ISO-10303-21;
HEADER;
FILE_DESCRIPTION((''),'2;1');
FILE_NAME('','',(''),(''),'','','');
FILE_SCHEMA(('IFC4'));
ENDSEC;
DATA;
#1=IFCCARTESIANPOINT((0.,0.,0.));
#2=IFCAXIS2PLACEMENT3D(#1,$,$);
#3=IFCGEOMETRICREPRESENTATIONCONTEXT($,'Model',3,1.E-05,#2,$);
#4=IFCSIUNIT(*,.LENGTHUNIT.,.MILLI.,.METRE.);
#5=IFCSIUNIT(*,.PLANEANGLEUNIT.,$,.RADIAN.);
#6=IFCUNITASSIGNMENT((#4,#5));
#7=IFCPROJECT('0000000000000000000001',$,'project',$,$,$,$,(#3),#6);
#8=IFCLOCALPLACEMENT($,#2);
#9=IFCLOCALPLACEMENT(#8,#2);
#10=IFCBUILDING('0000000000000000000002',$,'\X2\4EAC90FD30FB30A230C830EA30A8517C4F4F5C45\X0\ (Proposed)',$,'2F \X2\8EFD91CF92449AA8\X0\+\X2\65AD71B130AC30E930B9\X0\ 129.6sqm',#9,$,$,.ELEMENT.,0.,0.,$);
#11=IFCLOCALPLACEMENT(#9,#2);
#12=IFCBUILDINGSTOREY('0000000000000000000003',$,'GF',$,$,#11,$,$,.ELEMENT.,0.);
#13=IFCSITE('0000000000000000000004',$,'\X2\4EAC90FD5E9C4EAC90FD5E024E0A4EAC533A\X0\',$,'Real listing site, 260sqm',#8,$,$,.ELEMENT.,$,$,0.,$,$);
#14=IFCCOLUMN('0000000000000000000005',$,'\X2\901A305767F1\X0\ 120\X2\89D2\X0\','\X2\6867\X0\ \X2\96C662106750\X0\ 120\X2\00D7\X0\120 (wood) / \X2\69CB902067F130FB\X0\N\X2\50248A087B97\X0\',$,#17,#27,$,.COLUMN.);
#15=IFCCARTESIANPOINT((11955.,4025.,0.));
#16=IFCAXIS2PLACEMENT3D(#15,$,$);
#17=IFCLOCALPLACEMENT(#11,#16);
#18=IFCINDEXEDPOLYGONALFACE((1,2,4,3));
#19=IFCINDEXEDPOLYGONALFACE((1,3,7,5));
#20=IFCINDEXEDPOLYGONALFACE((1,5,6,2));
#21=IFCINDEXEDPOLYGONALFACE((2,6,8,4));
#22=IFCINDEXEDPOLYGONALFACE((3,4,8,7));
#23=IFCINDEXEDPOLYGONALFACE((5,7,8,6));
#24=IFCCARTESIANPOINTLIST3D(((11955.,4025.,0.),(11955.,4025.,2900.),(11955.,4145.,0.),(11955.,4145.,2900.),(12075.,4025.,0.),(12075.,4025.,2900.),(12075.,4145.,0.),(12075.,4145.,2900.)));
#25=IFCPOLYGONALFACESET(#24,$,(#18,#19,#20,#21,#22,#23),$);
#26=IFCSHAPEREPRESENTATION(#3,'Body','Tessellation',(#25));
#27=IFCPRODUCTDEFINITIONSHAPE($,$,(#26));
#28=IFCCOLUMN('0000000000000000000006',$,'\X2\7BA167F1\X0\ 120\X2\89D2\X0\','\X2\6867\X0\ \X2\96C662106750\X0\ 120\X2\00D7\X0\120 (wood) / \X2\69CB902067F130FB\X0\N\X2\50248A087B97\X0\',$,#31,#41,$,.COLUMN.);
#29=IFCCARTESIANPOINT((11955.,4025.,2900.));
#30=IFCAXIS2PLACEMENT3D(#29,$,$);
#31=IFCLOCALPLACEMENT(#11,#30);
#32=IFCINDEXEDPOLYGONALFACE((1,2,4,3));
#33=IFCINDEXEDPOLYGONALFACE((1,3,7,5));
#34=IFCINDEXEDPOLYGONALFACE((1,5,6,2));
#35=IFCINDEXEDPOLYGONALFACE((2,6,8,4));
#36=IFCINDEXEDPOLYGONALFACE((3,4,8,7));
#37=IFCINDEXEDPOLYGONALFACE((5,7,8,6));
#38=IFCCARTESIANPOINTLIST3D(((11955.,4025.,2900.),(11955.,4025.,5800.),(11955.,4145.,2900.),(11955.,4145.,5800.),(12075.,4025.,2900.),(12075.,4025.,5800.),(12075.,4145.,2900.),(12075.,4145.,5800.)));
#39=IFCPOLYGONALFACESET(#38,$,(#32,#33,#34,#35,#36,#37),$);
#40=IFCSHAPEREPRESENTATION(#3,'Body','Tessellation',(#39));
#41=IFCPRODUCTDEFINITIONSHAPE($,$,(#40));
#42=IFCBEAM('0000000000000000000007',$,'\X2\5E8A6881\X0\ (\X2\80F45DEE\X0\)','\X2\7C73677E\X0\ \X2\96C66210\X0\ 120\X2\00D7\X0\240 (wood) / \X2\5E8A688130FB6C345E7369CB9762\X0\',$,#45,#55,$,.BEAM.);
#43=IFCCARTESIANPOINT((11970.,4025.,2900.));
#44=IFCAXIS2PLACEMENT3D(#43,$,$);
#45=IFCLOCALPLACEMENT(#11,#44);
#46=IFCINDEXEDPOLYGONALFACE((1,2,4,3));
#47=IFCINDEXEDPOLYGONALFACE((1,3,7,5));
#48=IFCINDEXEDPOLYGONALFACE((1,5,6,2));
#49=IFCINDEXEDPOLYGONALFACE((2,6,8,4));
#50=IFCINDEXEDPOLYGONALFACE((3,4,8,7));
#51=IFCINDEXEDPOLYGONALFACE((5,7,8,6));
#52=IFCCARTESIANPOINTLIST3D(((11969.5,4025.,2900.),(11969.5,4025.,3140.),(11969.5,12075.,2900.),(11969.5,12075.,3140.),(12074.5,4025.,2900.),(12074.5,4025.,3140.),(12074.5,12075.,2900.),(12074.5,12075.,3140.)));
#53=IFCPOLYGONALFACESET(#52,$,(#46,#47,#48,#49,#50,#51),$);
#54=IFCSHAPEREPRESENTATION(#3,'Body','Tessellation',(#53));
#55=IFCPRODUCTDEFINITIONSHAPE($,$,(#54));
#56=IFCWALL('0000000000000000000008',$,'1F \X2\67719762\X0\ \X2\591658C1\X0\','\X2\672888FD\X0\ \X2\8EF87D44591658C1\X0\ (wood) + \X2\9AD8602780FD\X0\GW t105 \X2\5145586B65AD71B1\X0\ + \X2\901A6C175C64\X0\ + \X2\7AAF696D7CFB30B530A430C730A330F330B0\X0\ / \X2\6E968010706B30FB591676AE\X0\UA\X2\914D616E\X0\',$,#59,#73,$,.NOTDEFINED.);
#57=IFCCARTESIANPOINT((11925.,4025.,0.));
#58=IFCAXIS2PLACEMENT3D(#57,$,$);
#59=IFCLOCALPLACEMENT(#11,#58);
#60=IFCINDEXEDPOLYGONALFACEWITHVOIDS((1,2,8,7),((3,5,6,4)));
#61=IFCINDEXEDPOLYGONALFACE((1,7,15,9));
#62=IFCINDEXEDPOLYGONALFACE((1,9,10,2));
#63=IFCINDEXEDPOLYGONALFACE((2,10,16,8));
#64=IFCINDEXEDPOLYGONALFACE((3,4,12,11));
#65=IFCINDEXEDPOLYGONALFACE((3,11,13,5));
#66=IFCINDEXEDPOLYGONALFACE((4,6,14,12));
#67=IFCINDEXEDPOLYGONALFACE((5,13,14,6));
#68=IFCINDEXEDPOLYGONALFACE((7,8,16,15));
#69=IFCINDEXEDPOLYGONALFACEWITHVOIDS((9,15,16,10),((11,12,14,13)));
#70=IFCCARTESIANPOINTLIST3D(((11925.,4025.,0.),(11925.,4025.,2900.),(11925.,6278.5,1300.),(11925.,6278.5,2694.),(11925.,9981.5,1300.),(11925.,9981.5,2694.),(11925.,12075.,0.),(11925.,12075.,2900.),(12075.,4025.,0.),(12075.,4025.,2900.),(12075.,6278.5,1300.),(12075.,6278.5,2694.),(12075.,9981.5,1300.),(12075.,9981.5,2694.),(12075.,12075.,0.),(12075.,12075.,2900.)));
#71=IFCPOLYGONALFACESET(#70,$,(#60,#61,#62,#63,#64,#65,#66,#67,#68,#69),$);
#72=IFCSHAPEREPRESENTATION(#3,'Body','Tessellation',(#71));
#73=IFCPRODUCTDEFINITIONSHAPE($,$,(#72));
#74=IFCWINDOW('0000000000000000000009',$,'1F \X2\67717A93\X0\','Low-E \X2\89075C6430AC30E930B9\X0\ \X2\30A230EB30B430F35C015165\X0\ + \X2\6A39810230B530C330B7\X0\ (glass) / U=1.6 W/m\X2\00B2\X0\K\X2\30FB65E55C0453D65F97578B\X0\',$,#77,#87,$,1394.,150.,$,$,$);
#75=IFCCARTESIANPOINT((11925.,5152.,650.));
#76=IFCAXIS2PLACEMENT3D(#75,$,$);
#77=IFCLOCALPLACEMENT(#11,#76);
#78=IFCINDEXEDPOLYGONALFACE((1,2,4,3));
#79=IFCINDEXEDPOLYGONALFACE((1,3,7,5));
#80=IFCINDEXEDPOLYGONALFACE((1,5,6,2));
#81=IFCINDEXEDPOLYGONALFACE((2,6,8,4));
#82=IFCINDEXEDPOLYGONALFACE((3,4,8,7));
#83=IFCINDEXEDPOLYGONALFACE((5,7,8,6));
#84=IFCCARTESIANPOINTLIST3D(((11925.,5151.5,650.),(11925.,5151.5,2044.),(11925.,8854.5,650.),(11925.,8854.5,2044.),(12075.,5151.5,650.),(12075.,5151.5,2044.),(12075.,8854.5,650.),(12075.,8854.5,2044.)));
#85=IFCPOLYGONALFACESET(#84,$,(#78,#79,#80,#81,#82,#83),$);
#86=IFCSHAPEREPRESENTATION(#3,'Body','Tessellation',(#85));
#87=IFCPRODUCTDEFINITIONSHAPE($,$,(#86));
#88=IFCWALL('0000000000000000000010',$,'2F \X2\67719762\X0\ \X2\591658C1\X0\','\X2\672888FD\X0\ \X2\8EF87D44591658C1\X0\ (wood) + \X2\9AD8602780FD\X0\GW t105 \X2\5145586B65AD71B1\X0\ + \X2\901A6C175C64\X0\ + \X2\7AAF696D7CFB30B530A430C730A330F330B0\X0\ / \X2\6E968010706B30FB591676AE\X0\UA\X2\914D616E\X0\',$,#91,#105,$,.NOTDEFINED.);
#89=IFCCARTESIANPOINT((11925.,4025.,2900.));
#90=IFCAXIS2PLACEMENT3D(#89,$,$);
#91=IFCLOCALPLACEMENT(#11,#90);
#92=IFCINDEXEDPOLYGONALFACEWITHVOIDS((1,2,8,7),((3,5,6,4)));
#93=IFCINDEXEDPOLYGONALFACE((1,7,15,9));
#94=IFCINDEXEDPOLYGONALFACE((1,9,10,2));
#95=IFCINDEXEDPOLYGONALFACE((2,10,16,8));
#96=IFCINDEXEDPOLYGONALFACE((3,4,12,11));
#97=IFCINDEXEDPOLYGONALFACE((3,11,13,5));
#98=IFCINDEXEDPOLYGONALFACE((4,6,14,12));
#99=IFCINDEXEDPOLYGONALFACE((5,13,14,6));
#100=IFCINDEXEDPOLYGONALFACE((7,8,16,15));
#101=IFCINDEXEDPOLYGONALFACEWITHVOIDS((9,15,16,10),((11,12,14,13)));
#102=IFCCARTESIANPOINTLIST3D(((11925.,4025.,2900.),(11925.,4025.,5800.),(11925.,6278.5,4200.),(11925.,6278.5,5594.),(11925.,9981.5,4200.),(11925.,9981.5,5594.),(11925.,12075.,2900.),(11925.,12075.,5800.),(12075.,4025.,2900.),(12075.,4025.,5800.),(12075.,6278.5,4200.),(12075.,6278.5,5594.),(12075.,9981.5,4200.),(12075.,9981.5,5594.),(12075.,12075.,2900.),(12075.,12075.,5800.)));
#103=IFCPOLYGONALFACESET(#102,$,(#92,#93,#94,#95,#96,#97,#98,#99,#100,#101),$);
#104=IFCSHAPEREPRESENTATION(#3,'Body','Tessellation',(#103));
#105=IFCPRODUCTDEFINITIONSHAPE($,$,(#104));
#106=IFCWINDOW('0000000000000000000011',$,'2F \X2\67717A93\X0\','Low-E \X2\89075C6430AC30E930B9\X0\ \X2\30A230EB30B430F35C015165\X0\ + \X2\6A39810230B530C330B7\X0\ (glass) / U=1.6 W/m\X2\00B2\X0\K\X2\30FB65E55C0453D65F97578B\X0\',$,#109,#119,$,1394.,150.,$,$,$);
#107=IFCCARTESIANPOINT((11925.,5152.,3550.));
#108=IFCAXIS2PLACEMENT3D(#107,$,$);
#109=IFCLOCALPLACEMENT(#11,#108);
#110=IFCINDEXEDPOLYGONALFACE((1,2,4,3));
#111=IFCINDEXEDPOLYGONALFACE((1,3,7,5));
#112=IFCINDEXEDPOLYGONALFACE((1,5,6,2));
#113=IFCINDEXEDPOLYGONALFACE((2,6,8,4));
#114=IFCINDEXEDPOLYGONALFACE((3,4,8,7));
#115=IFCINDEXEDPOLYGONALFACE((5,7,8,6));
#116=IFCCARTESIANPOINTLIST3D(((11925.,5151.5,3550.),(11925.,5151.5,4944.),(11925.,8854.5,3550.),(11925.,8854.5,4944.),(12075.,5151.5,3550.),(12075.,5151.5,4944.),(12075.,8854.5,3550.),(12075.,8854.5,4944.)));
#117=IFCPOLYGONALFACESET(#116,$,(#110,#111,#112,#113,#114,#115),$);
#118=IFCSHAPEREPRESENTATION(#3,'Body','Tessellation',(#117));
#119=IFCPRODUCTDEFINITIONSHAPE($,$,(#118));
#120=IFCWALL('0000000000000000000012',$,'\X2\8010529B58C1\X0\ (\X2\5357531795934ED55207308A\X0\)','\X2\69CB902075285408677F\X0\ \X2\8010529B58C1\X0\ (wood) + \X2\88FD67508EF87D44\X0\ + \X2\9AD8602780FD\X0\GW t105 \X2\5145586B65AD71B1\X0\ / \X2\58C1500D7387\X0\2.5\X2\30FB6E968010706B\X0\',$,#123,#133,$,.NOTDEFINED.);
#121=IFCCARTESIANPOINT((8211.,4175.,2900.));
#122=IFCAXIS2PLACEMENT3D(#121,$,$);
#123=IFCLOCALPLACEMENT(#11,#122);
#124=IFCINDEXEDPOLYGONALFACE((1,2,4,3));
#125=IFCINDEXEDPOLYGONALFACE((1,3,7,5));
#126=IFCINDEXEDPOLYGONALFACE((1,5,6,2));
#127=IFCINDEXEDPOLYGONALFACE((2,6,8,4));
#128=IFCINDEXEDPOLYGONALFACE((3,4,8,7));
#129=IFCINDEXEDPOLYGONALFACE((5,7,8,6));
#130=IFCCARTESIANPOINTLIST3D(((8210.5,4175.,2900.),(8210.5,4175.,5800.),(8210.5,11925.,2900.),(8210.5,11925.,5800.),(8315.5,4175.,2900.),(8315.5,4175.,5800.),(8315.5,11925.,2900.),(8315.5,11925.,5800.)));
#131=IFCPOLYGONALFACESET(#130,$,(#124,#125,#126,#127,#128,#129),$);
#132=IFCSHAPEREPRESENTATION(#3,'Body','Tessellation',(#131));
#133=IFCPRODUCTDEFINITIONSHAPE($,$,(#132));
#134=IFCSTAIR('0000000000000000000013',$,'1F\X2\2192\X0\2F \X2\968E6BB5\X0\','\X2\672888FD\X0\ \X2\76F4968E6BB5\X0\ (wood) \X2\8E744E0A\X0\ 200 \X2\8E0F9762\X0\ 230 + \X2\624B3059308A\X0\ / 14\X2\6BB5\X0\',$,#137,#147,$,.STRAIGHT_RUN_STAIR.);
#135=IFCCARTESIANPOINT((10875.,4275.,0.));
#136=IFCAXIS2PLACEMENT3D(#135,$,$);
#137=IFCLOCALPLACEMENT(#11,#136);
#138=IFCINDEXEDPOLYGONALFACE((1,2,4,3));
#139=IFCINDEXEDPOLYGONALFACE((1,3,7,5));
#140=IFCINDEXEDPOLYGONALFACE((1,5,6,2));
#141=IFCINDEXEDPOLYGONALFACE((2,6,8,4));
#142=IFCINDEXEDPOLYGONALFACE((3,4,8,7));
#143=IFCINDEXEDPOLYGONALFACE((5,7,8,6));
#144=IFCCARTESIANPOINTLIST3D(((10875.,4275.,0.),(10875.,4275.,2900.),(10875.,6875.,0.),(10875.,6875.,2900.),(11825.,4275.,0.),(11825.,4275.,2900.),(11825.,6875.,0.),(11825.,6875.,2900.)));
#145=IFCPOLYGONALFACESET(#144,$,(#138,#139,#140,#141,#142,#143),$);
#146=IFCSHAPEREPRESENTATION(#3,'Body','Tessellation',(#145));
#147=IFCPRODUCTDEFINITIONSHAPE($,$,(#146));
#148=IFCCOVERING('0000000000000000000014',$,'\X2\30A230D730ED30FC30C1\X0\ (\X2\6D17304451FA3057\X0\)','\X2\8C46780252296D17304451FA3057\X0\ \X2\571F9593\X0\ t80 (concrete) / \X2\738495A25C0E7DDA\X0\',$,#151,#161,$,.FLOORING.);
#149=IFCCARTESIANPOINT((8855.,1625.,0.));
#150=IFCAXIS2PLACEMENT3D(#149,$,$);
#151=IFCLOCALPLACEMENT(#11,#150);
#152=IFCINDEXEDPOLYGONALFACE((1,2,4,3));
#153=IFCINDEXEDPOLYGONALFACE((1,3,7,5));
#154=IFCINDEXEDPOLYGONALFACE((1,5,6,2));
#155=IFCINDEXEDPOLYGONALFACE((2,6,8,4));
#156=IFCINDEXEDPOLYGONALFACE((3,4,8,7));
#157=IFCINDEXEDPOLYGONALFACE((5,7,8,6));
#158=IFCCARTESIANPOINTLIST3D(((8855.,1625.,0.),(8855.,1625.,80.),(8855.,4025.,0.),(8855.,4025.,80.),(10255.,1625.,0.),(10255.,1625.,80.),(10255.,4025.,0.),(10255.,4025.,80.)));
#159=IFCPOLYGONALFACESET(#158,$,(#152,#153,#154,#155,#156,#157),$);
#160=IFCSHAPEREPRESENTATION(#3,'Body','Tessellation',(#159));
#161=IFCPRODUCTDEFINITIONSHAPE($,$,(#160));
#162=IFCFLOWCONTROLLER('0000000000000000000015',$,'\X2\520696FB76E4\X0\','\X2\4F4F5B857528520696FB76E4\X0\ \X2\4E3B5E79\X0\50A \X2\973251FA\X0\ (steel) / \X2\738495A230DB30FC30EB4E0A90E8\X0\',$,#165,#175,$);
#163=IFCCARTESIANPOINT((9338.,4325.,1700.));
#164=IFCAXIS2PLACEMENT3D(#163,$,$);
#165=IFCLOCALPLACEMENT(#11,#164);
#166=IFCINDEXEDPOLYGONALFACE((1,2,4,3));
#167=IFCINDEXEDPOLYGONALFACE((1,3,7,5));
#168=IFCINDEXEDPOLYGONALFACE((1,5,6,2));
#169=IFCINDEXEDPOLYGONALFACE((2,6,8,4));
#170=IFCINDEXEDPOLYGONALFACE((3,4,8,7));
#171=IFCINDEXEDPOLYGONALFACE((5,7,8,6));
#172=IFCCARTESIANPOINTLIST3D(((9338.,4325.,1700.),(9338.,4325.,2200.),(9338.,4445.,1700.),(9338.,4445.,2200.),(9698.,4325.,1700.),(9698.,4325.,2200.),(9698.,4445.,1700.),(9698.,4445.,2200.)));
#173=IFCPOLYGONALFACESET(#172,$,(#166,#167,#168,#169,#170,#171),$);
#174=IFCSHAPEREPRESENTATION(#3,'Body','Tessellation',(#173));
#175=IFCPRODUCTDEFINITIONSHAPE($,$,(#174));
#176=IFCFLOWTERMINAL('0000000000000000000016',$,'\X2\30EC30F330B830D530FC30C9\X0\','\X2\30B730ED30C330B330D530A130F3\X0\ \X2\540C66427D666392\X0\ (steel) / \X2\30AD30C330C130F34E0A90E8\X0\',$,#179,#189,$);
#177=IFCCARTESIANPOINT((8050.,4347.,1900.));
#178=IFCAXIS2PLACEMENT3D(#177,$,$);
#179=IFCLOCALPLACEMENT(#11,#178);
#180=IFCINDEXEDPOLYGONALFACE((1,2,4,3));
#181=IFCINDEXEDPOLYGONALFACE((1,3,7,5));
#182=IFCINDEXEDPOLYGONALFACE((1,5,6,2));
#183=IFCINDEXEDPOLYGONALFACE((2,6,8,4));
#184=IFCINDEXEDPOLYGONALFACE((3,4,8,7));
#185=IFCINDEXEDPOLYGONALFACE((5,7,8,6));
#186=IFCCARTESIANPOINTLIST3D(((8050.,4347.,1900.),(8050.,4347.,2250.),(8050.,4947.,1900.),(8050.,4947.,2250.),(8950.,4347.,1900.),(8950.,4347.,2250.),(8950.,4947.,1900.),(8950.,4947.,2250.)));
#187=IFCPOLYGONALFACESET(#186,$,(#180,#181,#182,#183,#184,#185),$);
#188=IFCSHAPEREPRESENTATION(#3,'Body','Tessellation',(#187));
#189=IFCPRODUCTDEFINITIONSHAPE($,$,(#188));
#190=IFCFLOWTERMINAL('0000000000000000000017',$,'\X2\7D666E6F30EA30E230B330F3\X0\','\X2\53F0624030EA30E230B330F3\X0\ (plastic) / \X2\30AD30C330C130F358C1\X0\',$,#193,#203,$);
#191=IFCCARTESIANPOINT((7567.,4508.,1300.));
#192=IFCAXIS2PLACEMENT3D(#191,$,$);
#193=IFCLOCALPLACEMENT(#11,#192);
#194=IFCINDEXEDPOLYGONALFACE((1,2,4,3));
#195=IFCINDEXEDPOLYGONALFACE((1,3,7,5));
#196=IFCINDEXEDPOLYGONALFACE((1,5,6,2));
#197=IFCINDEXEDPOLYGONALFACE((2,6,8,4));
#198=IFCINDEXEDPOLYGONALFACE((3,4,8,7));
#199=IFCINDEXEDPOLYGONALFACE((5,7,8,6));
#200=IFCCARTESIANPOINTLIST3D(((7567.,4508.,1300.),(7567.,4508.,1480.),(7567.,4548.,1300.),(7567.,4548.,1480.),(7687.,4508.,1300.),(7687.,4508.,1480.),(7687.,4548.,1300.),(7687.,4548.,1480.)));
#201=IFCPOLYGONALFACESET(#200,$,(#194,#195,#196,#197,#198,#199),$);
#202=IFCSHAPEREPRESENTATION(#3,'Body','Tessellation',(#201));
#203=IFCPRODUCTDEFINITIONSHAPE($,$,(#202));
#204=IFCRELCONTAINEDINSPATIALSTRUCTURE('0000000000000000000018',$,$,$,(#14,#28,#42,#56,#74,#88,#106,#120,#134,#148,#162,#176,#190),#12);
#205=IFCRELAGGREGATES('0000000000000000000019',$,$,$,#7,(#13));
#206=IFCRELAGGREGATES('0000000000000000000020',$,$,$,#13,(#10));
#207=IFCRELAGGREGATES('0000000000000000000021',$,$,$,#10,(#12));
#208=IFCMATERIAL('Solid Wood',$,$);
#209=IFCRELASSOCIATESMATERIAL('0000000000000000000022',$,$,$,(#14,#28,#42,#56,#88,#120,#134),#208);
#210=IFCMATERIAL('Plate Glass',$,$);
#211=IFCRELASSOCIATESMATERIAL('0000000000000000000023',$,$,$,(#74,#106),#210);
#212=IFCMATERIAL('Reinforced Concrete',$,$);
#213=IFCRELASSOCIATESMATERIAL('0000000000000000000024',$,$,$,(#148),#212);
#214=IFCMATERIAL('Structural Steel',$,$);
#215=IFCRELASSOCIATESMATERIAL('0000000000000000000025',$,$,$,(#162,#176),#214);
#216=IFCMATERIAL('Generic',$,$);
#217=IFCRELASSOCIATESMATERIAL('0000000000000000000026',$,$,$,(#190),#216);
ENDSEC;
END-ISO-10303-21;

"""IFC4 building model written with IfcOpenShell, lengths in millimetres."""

from ifc_helpers import new_model, si_unit, frame, frame_2d, origin, place, context, project, spatial, rectangle, extrude, material, element, fill, save


model = new_model("IFC4")

# Units and contexts
model_context = context("Model", 3, precision=1e-05, world=origin())
ifc_project = project(units=[si_unit("LENGTHUNIT", "METRE", prefix="MILLI"), si_unit("PLANEANGLEUNIT", "RADIAN")], contexts=[model_context])

# Site, building, storey
site_placement = place(None, origin())
site = spatial("IfcSite", under=ifc_project, at=site_placement, Name="京都府京都市上京区", ObjectType="Real listing site, 260sqm", CompositionType="ELEMENT", RefElevation=0.0)
building_placement = place(site_placement, origin())
building = spatial("IfcBuilding", under=site, at=building_placement, Name="京都・アトリエ兼住居 (Proposed)", ObjectType="2F 軽量鉄骨+断熱ガラス 129.6sqm", CompositionType="ELEMENT", ElevationOfRefHeight=0.0, ElevationOfTerrain=0.0)
storey_placement = place(building_placement, origin())
storey = spatial("IfcBuildingStorey", under=building, at=storey_placement, Name="GF", CompositionType="ELEMENT", Elevation=0.0)

# Columns
ifc_material_1 = material(Name="Solid Wood")
column_1_placement = place(storey_placement, frame((11955.0, 4025.0, 0.0)))
element("IfcColumn", 1, at=column_1_placement, inside=storey, material=ifc_material_1, Name="通し柱 120角", Description="桧 集成材 120×120 (wood) / 構造柱・N値計算", PredefinedType="COLUMN", context=model_context, shape_type="SweptSolid", body=[
    extrude(rectangle(XDim=120.0, YDim=120.0, at=frame_2d((60.0, 60.0))), frame((11955.0, 4025.0, 0.0)), (0.0, 0.0, 1.0), 2900.0),
])
column_2_placement = place(storey_placement, frame((11955.0, 4025.0, 2900.0)))
element("IfcColumn", 2, at=column_2_placement, inside=storey, material=ifc_material_1, Name="管柱 120角", Description="桧 集成材 120×120 (wood) / 構造柱・N値計算", PredefinedType="COLUMN", context=model_context, shape_type="SweptSolid", body=[
    extrude(rectangle(XDim=120.0, YDim=120.0, at=frame_2d((60.0, 60.0))), frame((11955.0, 4025.0, 2900.0)), (0.0, 0.0, 1.0), 2900.0),
])

# Beam
beam_1_placement = place(storey_placement, frame((11970.0, 4025.0, 2900.0)))
element("IfcBeam", 3, at=beam_1_placement, inside=storey, material=ifc_material_1, Name="床梁 (胴差)", Description="米松 集成 120×240 (wood) / 床梁・水平構面", PredefinedType="BEAM", context=model_context, shape_type="SweptSolid", body=[
    extrude(rectangle(XDim=105.0, YDim=8050.0, at=frame_2d((52.0, 4025.0))), frame((11970.0, 4025.0, 2900.0)), (0.0, 0.0, 1.0), 240.0),
])

# Wall, opening, window
wall_1_placement = place(storey_placement, frame((11925.0, 4025.0, 0.0)))
wall_1 = element("IfcWall", 4, at=wall_1_placement, inside=storey, material=ifc_material_1, Name="1F 東面 外壁", Description="木製 軸組外壁 (wood) + 高性能GW t105 充填断熱 + 通気層 + 窯業系サイディング / 準耐火・外皮UA配慮", PredefinedType="NOTDEFINED", context=model_context, shape_type="SweptSolid", body=[
    extrude(rectangle(XDim=150.0, YDim=8050.0, at=frame_2d((75.0, 4025.0))), frame((11925.0, 4025.0, 0.0)), (0.0, 0.0, 1.0), 2900.0),
])
opening_1_placement = place(storey_placement, frame((11925.0, 5152.0, 650.0)))
opening_1 = element("IfcOpeningElement", 5, at=opening_1_placement, cuts=wall_1, PredefinedType="NOTDEFINED", context=model_context, shape_type="SweptSolid", body=[
    extrude(rectangle(XDim=150.0, YDim=3703.0, at=frame_2d((75.0, 1851.0))), frame((11925.0, 5152.0, 650.0)), (0.0, 0.0, 1.0), 1394.0),
])
ifc_material_2 = material(Name="Plate Glass")
window_1_placement = place(storey_placement, frame((11925.0, 5152.0, 650.0)))
window_1 = element("IfcWindow", 6, at=window_1_placement, inside=storey, material=ifc_material_2, Name="1F 東窓", Description="Low-E 複層ガラス アルゴン封入 + 樹脂サッシ (glass) / U=1.6 W/m²K・日射取得型", OverallHeight=1394.0, OverallWidth=150.0, context=model_context, shape_type="SweptSolid", body=[
    extrude(rectangle(XDim=150.0, YDim=3703.0, at=frame_2d((75.0, 1851.0))), frame((11925.0, 5152.0, 650.0)), (0.0, 0.0, 1.0), 1394.0),
])
fill(opening_1, window_1)

# Wall, opening, window
wall_2_placement = place(storey_placement, frame((11925.0, 4025.0, 2900.0)))
wall_2 = element("IfcWall", 7, at=wall_2_placement, inside=storey, material=ifc_material_1, Name="2F 東面 外壁", Description="木製 軸組外壁 (wood) + 高性能GW t105 充填断熱 + 通気層 + 窯業系サイディング / 準耐火・外皮UA配慮", PredefinedType="NOTDEFINED", context=model_context, shape_type="SweptSolid", body=[
    extrude(rectangle(XDim=150.0, YDim=8050.0, at=frame_2d((75.0, 4025.0))), frame((11925.0, 4025.0, 2900.0)), (0.0, 0.0, 1.0), 2900.0),
])
opening_2_placement = place(storey_placement, frame((11925.0, 5152.0, 3550.0)))
opening_2 = element("IfcOpeningElement", 8, at=opening_2_placement, cuts=wall_2, PredefinedType="NOTDEFINED", context=model_context, shape_type="SweptSolid", body=[
    extrude(rectangle(XDim=150.0, YDim=3703.0, at=frame_2d((75.0, 1851.0))), frame((11925.0, 5152.0, 3550.0)), (0.0, 0.0, 1.0), 1394.0),
])
window_2_placement = place(storey_placement, frame((11925.0, 5152.0, 3550.0)))
window_2 = element("IfcWindow", 9, at=window_2_placement, inside=storey, material=ifc_material_2, Name="2F 東窓", Description="Low-E 複層ガラス アルゴン封入 + 樹脂サッシ (glass) / U=1.6 W/m²K・日射取得型", OverallHeight=1394.0, OverallWidth=150.0, context=model_context, shape_type="SweptSolid", body=[
    extrude(rectangle(XDim=150.0, YDim=3703.0, at=frame_2d((75.0, 1851.0))), frame((11925.0, 5152.0, 3550.0)), (0.0, 0.0, 1.0), 1394.0),
])
fill(opening_2, window_2)

# Wall
wall_3_placement = place(storey_placement, frame((8211.0, 4175.0, 2900.0)))
element("IfcWall", 10, at=wall_3_placement, inside=storey, material=ifc_material_1, Name="耐力壁 (南北間仕切り)", Description="構造用合板 耐力壁 (wood) + 製材軸組 + 高性能GW t105 充填断熱 / 壁倍率2.5・準耐火", PredefinedType="NOTDEFINED", context=model_context, shape_type="SweptSolid", body=[
    extrude(rectangle(XDim=105.0, YDim=7750.0, at=frame_2d((52.0, 3875.0))), frame((8211.0, 4175.0, 2900.0)), (0.0, 0.0, 1.0), 2900.0),
])

# Stair
stair_placement = place(storey_placement, frame((10875.0, 4275.0, 0.0)))
element("IfcStair", 11, at=stair_placement, inside=storey, material=ifc_material_1, Name="1F→2F 階段", Description="木製 直階段 (wood) 蹴上 200 踏面 230 + 手すり / 14段", PredefinedType="STRAIGHT_RUN_STAIR", context=model_context, shape_type="SweptSolid", body=[
    extrude(rectangle(XDim=950.0, YDim=2600.0, at=frame_2d((475.0, 1300.0))), frame((10875.0, 4275.0, 0.0)), (0.0, 0.0, 1.0), 2900.0),
])

# Covering
ifc_material_3 = material(Name="Reinforced Concrete")
covering_placement = place(storey_placement, frame((8855.0, 1625.0, 0.0)))
element("IfcCovering", 12, at=covering_placement, inside=storey, material=ifc_material_3, Name="アプローチ (洗い出し)", Description="豆砂利洗い出し 土間 t80 (concrete) / 玄関導線", PredefinedType="FLOORING", context=model_context, shape_type="SweptSolid", body=[
    extrude(rectangle(XDim=1400.0, YDim=2400.0, at=frame_2d((700.0, 1200.0))), frame((8855.0, 1625.0, 0.0)), (0.0, 0.0, 1.0), 80.0),
])

# Flow controller
ifc_material_4 = material(Name="Structural Steel")
flow_controller_placement = place(storey_placement, frame((9338.0, 4325.0, 1700.0)))
element("IfcFlowController", 13, at=flow_controller_placement, inside=storey, material=ifc_material_4, Name="分電盤", Description="住宅用分電盤 主幹50A 露出 (steel) / 玄関ホール上部", context=model_context, shape_type="SweptSolid", body=[
    extrude(rectangle(XDim=360.0, YDim=120.0, at=frame_2d((180.0, 60.0))), frame((9338.0, 4325.0, 1700.0)), (0.0, 0.0, 1.0), 500.0),
])

# Flow terminals
flow_terminal_1_placement = place(storey_placement, frame((8050.0, 4347.0, 1900.0)))
element("IfcFlowTerminal", 14, at=flow_terminal_1_placement, inside=storey, material=ifc_material_4, Name="レンジフード", Description="シロッコファン 同時給排 (steel) / キッチン上部", context=model_context, shape_type="SweptSolid", body=[
    extrude(rectangle(XDim=900.0, YDim=600.0, at=frame_2d((450.0, 300.0))), frame((8050.0, 4347.0, 1900.0)), (0.0, 0.0, 1.0), 350.0),
])
ifc_material_5 = material(Name="Generic")
flow_terminal_2_placement = place(storey_placement, frame((7567.0, 4508.0, 1300.0)))
element("IfcFlowTerminal", 15, at=flow_terminal_2_placement, inside=storey, material=ifc_material_5, Name="給湯リモコン", Description="台所リモコン (plastic) / キッチン壁", context=model_context, shape_type="SweptSolid", body=[
    extrude(rectangle(XDim=120.0, YDim=40.0, at=frame_2d((60.0, 20.0))), frame((7567.0, 4508.0, 1300.0)), (0.0, 0.0, 1.0), 180.0),
])

save(model, "model.ifc")
